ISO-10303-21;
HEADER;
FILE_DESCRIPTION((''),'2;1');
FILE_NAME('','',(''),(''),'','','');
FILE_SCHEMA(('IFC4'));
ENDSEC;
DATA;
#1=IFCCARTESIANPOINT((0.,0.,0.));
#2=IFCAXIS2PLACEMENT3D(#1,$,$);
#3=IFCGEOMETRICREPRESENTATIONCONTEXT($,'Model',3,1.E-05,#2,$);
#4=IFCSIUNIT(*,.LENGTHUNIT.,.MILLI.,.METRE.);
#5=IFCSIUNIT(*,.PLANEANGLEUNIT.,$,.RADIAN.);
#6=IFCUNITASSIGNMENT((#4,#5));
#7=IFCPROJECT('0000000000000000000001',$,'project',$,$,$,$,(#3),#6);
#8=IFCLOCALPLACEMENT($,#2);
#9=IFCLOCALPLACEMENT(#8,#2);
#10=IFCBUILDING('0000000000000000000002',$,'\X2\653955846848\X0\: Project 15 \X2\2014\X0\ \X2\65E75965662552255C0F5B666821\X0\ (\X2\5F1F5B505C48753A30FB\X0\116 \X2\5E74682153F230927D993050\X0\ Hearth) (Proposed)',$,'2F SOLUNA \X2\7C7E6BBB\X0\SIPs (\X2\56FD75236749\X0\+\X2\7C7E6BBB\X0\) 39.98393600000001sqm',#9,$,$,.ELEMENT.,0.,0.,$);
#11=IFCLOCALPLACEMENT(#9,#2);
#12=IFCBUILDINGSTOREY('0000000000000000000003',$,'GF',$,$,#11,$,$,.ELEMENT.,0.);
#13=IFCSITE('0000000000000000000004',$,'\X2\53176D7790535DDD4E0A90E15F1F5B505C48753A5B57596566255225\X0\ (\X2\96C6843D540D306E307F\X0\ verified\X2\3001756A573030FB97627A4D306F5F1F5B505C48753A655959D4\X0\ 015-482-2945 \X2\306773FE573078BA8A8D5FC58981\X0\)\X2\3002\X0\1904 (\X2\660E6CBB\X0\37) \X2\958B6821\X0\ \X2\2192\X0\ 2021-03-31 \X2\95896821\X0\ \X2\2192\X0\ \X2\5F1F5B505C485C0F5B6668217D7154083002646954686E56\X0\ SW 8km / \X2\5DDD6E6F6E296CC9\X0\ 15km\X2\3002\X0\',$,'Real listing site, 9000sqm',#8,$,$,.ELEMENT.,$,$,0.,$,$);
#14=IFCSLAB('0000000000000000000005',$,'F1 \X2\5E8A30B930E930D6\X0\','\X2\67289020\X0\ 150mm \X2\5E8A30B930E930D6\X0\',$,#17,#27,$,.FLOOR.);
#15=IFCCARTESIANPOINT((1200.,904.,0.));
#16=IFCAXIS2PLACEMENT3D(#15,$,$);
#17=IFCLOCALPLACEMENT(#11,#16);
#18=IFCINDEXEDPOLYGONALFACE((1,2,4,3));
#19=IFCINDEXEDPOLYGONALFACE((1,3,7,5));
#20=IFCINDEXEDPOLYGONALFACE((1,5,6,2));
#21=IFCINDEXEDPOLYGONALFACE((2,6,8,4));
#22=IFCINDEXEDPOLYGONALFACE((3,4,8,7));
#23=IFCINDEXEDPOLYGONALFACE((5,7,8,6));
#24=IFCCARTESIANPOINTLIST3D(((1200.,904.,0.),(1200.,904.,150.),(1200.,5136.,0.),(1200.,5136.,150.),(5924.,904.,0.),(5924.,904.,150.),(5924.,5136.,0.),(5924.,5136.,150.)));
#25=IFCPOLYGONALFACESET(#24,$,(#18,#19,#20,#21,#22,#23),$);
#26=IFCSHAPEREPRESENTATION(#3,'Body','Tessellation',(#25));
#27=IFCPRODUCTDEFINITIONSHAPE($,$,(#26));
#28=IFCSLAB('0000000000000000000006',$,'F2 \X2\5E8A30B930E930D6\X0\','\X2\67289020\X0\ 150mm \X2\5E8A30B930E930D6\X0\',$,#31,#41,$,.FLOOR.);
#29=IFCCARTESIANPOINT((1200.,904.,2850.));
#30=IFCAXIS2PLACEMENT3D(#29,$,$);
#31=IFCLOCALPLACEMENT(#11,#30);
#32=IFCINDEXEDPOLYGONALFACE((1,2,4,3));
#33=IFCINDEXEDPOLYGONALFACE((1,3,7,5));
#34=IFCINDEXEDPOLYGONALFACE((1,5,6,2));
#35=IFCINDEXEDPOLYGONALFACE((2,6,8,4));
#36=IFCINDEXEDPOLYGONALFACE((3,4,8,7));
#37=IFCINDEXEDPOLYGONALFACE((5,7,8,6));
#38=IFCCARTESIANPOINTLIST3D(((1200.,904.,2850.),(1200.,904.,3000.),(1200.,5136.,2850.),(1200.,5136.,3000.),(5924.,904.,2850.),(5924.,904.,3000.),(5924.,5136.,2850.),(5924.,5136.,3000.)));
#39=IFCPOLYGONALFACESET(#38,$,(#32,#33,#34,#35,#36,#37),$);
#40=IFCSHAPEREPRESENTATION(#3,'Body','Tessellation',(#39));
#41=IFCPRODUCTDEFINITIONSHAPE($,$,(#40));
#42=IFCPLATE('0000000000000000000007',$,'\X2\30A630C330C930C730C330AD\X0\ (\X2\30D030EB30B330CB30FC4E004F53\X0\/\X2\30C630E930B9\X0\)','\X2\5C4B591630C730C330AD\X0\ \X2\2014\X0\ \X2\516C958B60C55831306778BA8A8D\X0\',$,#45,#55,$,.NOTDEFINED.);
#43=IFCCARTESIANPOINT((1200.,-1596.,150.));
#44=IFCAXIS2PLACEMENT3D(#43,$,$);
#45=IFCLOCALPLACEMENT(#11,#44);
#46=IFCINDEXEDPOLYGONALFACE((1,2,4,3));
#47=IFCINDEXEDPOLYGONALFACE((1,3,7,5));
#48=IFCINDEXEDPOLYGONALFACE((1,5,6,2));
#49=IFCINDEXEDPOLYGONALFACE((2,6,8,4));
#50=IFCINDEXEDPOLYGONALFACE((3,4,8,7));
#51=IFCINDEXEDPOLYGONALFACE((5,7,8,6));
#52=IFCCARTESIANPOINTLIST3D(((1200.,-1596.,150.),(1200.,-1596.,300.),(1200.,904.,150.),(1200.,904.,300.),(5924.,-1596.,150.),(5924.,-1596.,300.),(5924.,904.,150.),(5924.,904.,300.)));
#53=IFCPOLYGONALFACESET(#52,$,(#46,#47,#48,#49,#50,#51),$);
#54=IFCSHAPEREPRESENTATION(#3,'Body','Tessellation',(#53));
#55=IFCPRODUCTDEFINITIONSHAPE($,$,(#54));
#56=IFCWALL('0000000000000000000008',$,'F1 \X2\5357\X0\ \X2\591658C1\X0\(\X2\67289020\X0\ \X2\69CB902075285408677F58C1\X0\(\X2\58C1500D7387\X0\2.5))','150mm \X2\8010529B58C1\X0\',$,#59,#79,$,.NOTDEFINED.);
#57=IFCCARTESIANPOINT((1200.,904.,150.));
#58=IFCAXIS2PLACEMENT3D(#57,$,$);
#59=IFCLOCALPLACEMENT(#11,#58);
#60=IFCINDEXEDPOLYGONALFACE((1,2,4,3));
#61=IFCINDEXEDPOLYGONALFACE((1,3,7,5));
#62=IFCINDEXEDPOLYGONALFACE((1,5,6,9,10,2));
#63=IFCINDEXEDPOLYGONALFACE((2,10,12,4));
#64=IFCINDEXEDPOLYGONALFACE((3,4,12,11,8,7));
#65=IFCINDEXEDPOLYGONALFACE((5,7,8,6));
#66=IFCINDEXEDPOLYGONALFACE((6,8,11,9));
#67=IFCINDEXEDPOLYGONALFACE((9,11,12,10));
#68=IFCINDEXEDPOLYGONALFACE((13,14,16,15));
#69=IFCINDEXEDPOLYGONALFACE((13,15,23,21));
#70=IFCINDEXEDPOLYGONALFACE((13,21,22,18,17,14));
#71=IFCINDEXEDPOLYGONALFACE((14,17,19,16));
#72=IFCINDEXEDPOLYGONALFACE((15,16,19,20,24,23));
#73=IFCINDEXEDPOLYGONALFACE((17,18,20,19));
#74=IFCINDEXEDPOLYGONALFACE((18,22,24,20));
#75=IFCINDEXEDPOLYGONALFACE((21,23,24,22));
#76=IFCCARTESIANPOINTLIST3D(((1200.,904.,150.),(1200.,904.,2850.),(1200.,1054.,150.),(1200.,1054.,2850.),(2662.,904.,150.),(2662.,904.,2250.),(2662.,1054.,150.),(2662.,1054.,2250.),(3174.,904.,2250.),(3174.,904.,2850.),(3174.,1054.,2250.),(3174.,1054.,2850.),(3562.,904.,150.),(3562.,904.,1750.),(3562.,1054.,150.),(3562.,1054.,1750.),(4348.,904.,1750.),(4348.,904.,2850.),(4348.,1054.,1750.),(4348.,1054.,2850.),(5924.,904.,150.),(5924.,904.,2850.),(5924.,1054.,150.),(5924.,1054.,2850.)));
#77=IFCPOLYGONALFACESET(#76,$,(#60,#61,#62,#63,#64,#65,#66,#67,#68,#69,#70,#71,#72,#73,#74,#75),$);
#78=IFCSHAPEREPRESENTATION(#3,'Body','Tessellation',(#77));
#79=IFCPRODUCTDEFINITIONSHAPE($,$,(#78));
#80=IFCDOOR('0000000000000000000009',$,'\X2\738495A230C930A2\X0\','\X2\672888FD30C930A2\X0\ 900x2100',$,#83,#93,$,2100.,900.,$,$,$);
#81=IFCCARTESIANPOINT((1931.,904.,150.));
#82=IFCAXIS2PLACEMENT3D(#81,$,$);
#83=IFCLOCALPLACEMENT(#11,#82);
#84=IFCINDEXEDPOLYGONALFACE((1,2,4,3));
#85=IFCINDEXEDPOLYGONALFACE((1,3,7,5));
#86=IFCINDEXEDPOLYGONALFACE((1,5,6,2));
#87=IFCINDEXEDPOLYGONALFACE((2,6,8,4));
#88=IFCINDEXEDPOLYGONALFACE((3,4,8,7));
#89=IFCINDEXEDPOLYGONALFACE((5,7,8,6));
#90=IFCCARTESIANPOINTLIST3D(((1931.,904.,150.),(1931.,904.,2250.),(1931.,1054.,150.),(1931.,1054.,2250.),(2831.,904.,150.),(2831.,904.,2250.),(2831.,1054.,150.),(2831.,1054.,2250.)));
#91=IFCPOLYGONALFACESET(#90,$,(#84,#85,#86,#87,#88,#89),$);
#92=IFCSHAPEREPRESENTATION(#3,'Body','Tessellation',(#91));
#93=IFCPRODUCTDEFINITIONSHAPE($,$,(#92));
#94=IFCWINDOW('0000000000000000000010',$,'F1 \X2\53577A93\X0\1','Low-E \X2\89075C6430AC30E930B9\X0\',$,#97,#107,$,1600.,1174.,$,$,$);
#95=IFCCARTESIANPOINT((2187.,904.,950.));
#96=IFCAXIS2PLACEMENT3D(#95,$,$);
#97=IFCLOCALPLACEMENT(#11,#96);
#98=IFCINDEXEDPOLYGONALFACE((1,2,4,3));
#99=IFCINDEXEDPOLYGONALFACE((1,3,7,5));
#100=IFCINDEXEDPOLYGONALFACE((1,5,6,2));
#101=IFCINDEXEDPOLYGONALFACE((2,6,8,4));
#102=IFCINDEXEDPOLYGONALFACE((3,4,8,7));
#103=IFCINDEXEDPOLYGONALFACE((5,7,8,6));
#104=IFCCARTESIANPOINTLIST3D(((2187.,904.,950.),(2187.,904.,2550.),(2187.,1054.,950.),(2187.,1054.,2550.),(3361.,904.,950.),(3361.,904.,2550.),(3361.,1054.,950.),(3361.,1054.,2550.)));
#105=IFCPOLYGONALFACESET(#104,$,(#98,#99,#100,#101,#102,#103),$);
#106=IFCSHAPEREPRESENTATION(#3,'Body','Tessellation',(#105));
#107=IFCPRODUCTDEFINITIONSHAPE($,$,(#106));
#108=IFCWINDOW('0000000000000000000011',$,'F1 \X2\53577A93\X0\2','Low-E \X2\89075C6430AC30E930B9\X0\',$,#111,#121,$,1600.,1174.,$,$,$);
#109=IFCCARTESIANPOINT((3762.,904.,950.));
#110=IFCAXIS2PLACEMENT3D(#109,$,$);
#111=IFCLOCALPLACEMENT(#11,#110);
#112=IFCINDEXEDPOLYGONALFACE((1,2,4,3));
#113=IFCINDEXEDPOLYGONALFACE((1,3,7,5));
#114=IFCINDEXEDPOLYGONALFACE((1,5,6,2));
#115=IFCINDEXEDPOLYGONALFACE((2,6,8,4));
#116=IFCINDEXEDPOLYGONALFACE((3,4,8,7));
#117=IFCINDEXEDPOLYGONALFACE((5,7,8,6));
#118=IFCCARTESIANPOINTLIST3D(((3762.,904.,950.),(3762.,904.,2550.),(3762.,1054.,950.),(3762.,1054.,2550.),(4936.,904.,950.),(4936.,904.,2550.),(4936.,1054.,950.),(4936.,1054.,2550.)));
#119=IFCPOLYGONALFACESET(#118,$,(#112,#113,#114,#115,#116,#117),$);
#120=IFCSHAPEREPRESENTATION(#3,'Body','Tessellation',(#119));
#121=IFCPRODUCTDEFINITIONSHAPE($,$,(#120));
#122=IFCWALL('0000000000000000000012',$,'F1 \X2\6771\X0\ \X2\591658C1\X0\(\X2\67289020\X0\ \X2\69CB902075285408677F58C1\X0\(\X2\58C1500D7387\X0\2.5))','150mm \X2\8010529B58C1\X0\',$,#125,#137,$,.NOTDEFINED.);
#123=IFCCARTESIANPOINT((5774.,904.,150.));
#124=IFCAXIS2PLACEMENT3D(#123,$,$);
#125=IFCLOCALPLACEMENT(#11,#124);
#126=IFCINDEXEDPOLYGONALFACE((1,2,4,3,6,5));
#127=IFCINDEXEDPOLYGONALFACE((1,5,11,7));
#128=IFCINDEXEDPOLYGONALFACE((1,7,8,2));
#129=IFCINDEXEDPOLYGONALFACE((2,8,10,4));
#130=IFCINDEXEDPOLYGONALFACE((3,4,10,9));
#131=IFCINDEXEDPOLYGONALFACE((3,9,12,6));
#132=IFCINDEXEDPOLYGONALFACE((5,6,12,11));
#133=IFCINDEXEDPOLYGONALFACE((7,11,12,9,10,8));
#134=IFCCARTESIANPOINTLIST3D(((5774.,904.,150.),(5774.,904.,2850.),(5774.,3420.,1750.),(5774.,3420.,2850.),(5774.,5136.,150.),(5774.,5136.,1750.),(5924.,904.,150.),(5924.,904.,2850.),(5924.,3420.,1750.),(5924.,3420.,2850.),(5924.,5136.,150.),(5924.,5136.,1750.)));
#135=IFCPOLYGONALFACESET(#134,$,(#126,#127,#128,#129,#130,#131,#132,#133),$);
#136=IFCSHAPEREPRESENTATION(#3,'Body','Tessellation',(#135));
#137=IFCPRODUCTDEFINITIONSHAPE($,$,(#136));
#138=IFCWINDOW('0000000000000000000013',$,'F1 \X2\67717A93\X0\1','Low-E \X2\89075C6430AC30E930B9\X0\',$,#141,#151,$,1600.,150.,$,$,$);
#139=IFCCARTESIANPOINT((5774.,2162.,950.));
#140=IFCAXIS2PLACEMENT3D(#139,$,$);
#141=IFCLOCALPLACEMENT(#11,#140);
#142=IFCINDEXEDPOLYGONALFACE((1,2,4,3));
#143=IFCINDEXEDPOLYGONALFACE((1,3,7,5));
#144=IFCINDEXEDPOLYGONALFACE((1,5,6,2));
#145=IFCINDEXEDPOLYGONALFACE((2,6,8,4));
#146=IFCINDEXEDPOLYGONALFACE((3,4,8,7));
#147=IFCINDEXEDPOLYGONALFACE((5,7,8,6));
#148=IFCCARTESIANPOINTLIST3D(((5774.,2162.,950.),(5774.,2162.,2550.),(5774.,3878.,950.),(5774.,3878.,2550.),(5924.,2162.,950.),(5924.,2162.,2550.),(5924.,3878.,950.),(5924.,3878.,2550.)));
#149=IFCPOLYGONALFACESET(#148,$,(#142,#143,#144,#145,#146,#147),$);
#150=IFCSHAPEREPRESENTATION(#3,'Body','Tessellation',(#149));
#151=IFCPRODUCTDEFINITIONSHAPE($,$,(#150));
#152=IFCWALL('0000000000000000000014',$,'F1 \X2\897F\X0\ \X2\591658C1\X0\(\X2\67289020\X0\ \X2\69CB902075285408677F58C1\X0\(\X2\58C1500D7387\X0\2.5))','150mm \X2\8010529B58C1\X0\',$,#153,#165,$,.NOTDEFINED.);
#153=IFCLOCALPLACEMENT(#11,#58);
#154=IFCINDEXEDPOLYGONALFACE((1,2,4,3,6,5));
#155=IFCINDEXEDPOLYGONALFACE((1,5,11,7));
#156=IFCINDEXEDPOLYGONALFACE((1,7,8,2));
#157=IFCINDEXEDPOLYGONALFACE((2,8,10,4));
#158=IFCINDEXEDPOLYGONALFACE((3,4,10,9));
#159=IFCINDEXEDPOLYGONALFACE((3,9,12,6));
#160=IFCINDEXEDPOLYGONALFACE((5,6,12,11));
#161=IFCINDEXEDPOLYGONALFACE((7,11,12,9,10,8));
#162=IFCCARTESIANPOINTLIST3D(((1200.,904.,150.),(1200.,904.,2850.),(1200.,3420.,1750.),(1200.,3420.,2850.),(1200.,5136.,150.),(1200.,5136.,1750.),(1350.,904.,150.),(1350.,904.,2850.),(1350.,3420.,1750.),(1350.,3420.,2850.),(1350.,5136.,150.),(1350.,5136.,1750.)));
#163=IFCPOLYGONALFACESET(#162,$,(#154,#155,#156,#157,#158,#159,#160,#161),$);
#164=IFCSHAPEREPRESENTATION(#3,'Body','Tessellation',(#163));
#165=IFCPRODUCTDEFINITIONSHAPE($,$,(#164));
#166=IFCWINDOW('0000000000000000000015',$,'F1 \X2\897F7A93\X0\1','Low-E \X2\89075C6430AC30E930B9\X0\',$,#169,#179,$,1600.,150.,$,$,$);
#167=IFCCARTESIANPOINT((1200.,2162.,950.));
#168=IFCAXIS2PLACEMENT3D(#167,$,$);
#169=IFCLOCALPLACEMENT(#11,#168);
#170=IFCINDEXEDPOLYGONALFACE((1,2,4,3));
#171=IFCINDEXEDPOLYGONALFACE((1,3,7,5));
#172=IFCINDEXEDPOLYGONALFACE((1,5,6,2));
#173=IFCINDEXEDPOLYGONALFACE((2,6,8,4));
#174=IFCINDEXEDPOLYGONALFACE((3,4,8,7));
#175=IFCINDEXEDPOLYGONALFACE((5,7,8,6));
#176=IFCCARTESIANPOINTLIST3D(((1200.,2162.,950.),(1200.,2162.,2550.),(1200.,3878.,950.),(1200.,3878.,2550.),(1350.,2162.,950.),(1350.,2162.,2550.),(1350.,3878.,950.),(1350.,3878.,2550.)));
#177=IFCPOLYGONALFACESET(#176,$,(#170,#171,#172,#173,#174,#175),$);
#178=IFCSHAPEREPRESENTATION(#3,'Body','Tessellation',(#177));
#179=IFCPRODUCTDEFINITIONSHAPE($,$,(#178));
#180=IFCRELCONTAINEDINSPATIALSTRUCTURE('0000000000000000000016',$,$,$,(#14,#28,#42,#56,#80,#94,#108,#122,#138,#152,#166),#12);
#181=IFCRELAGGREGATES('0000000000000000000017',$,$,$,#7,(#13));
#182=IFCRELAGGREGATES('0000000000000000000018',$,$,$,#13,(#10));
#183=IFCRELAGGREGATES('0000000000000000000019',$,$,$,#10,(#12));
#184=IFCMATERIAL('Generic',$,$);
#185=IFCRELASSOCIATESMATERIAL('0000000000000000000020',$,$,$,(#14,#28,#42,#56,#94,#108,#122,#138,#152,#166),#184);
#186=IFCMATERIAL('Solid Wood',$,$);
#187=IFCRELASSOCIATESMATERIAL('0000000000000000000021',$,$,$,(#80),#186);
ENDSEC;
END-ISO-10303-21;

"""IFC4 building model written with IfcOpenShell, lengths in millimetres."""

from ifc_helpers import new_model, si_unit, frame, frame_2d, origin, place, context, project, spatial, rectangle, extrude, material, element, fill, save


model = new_model("IFC4")

# Units and contexts
model_context = context("Model", 3, precision=1e-05, world=origin())
ifc_project = project(units=[si_unit("LENGTHUNIT", "METRE", prefix="MILLI"), si_unit("PLANEANGLEUNIT", "RADIAN")], contexts=[model_context])

# Site, building, storey
site_placement = place(None, origin())
site = spatial("IfcSite", under=ifc_project, at=site_placement, Name="北海道川上郡弟子屈町字奥春別 (集落名のみ verified、番地・面積は弟子屈町教委 015-482-2945 で現地確認必要)。1904 (明治37) 開校 → 2021-03-31 閉校 → 弟子屈小学校統合。摩周湖 SW 8km / 川湯温泉 15km。", ObjectType="Real listing site, 9000sqm", CompositionType="ELEMENT", RefElevation=0.0)
building_placement = place(site_placement, origin())
building = spatial("IfcBuilding", under=site, at=building_placement, Name="改善案: Project 15 — 旧奥春別小学校 (弟子屈町・116 年校史を継ぐ Hearth) (Proposed)", ObjectType="2F SOLUNA 籾殻SIPs (国産杉+籾殻) 39.98393600000001sqm", CompositionType="ELEMENT", ElevationOfRefHeight=0.0, ElevationOfTerrain=0.0)
storey_placement = place(building_placement, origin())
storey = spatial("IfcBuildingStorey", under=building, at=storey_placement, Name="GF", CompositionType="ELEMENT", Elevation=0.0)

# Slabs
ifc_material_1 = material(Name="Generic")
slab_1_placement = place(storey_placement, frame((1200.0, 904.0, 0.0)))
element("IfcSlab", 1, at=slab_1_placement, inside=storey, material=ifc_material_1, Name="F1 床スラブ", Description="木造 150mm 床スラブ", PredefinedType="FLOOR", context=model_context, shape_type="SweptSolid", body=[
    extrude(rectangle(XDim=4724.0, YDim=4232.0, at=frame_2d((2362.0, 2116.0))), frame((1200.0, 904.0, 0.0)), (0.0, 0.0, 1.0), 150.0),
])
slab_2_placement = place(storey_placement, frame((1200.0, 904.0, 2850.0)))
element("IfcSlab", 2, at=slab_2_placement, inside=storey, material=ifc_material_1, Name="F2 床スラブ", Description="木造 150mm 床スラブ", PredefinedType="FLOOR", context=model_context, shape_type="SweptSolid", body=[
    extrude(rectangle(XDim=4724.0, YDim=4232.0, at=frame_2d((2362.0, 2116.0))), frame((1200.0, 904.0, 2850.0)), (0.0, 0.0, 1.0), 150.0),
])

# Plate
plate_placement = place(storey_placement, frame((1200.0, -1596.0, 150.0)))
element("IfcPlate", 3, at=plate_placement, inside=storey, material=ifc_material_1, Name="ウッドデッキ (バルコニー一体/テラス)", Description="屋外デッキ — 公開情報で確認", PredefinedType="NOTDEFINED", context=model_context, shape_type="SweptSolid", body=[
    extrude(rectangle(XDim=4724.0, YDim=2500.0, at=frame_2d((2362.0, 1250.0))), frame((1200.0, -1596.0, 150.0)), (0.0, 0.0, 1.0), 150.0),
])

# Wall, openings, door, windows
wall_1_placement = place(storey_placement, frame((1200.0, 904.0, 150.0)))
wall_1 = element("IfcWall", 4, at=wall_1_placement, inside=storey, material=ifc_material_1, Name="F1 南 外壁(木造 構造用合板壁(壁倍率2.5))", Description="150mm 耐力壁", PredefinedType="NOTDEFINED", context=model_context, shape_type="SweptSolid", body=[
    extrude(rectangle(XDim=4724.0, YDim=150.0, at=frame_2d((2362.0, 75.0))), frame((1200.0, 904.0, 150.0)), (0.0, 0.0, 1.0), 2700.0),
])
opening_1_placement = place(storey_placement, frame((1931.0, 904.0, 150.0)))
opening_1 = element("IfcOpeningElement", 5, at=opening_1_placement, cuts=wall_1, PredefinedType="NOTDEFINED", context=model_context, shape_type="SweptSolid", body=[
    extrude(rectangle(XDim=900.0, YDim=150.0, at=frame_2d((450.0, 75.0))), frame((1931.0, 904.0, 150.0)), (0.0, 0.0, 1.0), 2100.0),
])
opening_2_placement = place(storey_placement, frame((2187.0, 904.0, 950.0)))
opening_2 = element("IfcOpeningElement", 6, at=opening_2_placement, cuts=wall_1, PredefinedType="NOTDEFINED", context=model_context, shape_type="SweptSolid", body=[
    extrude(rectangle(XDim=1174.0, YDim=150.0, at=frame_2d((587.0, 75.0))), frame((2187.0, 904.0, 950.0)), (0.0, 0.0, 1.0), 1600.0),
])
opening_3_placement = place(storey_placement, frame((3762.0, 904.0, 950.0)))
opening_3 = element("IfcOpeningElement", 7, at=opening_3_placement, cuts=wall_1, PredefinedType="NOTDEFINED", context=model_context, shape_type="SweptSolid", body=[
    extrude(rectangle(XDim=1174.0, YDim=150.0, at=frame_2d((587.0, 75.0))), frame((3762.0, 904.0, 950.0)), (0.0, 0.0, 1.0), 1600.0),
])
ifc_material_2 = material(Name="Solid Wood")
door_placement = place(storey_placement, frame((1931.0, 904.0, 150.0)))
door = element("IfcDoor", 8, at=door_placement, inside=storey, material=ifc_material_2, Name="玄関ドア", Description="木製ドア 900x2100", OverallHeight=2100.0, OverallWidth=900.0, context=model_context, shape_type="SweptSolid", body=[
    extrude(rectangle(XDim=900.0, YDim=150.0, at=frame_2d((450.0, 75.0))), frame((1931.0, 904.0, 150.0)), (0.0, 0.0, 1.0), 2100.0),
])
fill(opening_1, door)
window_1_placement = place(storey_placement, frame((2187.0, 904.0, 950.0)))
window_1 = element("IfcWindow", 9, at=window_1_placement, inside=storey, material=ifc_material_1, Name="F1 南窓1", Description="Low-E 複層ガラス", OverallHeight=1600.0, OverallWidth=1174.0, context=model_context, shape_type="SweptSolid", body=[
    extrude(rectangle(XDim=1174.0, YDim=150.0, at=frame_2d((587.0, 75.0))), frame((2187.0, 904.0, 950.0)), (0.0, 0.0, 1.0), 1600.0),
])
fill(opening_2, window_1)
window_2_placement = place(storey_placement, frame((3762.0, 904.0, 950.0)))
window_2 = element("IfcWindow", 10, at=window_2_placement, inside=storey, material=ifc_material_1, Name="F1 南窓2", Description="Low-E 複層ガラス", OverallHeight=1600.0, OverallWidth=1174.0, context=model_context, shape_type="SweptSolid", body=[
    extrude(rectangle(XDim=1174.0, YDim=150.0, at=frame_2d((587.0, 75.0))), frame((3762.0, 904.0, 950.0)), (0.0, 0.0, 1.0), 1600.0),
])
fill(opening_3, window_2)

# Walls, openings, windows
wall_2_placement = place(storey_placement, frame((5774.0, 904.0, 150.0)))
wall_2 = element("IfcWall", 11, at=wall_2_placement, inside=storey, material=ifc_material_1, Name="F1 東 外壁(木造 構造用合板壁(壁倍率2.5))", Description="150mm 耐力壁", PredefinedType="NOTDEFINED", context=model_context, shape_type="SweptSolid", body=[
    extrude(rectangle(XDim=150.0, YDim=4232.0, at=frame_2d((75.0, 2116.0))), frame((5774.0, 904.0, 150.0)), (0.0, 0.0, 1.0), 2700.0),
])
opening_4_placement = place(storey_placement, frame((5774.0, 2162.0, 950.0)))
opening_4 = element("IfcOpeningElement", 12, at=opening_4_placement, cuts=wall_2, PredefinedType="NOTDEFINED", context=model_context, shape_type="SweptSolid", body=[
    extrude(rectangle(XDim=150.0, YDim=1716.0, at=frame_2d((75.0, 858.0))), frame((5774.0, 2162.0, 950.0)), (0.0, 0.0, 1.0), 1600.0),
])
window_3_placement = place(storey_placement, frame((5774.0, 2162.0, 950.0)))
window_3 = element("IfcWindow", 13, at=window_3_placement, inside=storey, material=ifc_material_1, Name="F1 東窓1", Description="Low-E 複層ガラス", OverallHeight=1600.0, OverallWidth=150.0, context=model_context, shape_type="SweptSolid", body=[
    extrude(rectangle(XDim=150.0, YDim=1716.0, at=frame_2d((75.0, 858.0))), frame((5774.0, 2162.0, 950.0)), (0.0, 0.0, 1.0), 1600.0),
])
fill(opening_4, window_3)
wall_3_placement = place(storey_placement, frame((1200.0, 904.0, 150.0)))
wall_3 = element("IfcWall", 14, at=wall_3_placement, inside=storey, material=ifc_material_1, Name="F1 西 外壁(木造 構造用合板壁(壁倍率2.5))", Description="150mm 耐力壁", PredefinedType="NOTDEFINED", context=model_context, shape_type="SweptSolid", body=[
    extrude(rectangle(XDim=150.0, YDim=4232.0, at=frame_2d((75.0, 2116.0))), frame((1200.0, 904.0, 150.0)), (0.0, 0.0, 1.0), 2700.0),
])
opening_5_placement = place(storey_placement, frame((1200.0, 2162.0, 950.0)))
opening_5 = element("IfcOpeningElement", 15, at=opening_5_placement, cuts=wall_3, PredefinedType="NOTDEFINED", context=model_context, shape_type="SweptSolid", body=[
    extrude(rectangle(XDim=150.0, YDim=1716.0, at=frame_2d((75.0, 858.0))), frame((1200.0, 2162.0, 950.0)), (0.0, 0.0, 1.0), 1600.0),
])
window_4_placement = place(storey_placement, frame((1200.0, 2162.0, 950.0)))
window_4 = element("IfcWindow", 16, at=window_4_placement, inside=storey, material=ifc_material_1, Name="F1 西窓1", Description="Low-E 複層ガラス", OverallHeight=1600.0, OverallWidth=150.0, context=model_context, shape_type="SweptSolid", body=[
    extrude(rectangle(XDim=150.0, YDim=1716.0, at=frame_2d((75.0, 858.0))), frame((1200.0, 2162.0, 950.0)), (0.0, 0.0, 1.0), 1600.0),
])
fill(opening_5, window_4)

save(model, "model.ifc")
